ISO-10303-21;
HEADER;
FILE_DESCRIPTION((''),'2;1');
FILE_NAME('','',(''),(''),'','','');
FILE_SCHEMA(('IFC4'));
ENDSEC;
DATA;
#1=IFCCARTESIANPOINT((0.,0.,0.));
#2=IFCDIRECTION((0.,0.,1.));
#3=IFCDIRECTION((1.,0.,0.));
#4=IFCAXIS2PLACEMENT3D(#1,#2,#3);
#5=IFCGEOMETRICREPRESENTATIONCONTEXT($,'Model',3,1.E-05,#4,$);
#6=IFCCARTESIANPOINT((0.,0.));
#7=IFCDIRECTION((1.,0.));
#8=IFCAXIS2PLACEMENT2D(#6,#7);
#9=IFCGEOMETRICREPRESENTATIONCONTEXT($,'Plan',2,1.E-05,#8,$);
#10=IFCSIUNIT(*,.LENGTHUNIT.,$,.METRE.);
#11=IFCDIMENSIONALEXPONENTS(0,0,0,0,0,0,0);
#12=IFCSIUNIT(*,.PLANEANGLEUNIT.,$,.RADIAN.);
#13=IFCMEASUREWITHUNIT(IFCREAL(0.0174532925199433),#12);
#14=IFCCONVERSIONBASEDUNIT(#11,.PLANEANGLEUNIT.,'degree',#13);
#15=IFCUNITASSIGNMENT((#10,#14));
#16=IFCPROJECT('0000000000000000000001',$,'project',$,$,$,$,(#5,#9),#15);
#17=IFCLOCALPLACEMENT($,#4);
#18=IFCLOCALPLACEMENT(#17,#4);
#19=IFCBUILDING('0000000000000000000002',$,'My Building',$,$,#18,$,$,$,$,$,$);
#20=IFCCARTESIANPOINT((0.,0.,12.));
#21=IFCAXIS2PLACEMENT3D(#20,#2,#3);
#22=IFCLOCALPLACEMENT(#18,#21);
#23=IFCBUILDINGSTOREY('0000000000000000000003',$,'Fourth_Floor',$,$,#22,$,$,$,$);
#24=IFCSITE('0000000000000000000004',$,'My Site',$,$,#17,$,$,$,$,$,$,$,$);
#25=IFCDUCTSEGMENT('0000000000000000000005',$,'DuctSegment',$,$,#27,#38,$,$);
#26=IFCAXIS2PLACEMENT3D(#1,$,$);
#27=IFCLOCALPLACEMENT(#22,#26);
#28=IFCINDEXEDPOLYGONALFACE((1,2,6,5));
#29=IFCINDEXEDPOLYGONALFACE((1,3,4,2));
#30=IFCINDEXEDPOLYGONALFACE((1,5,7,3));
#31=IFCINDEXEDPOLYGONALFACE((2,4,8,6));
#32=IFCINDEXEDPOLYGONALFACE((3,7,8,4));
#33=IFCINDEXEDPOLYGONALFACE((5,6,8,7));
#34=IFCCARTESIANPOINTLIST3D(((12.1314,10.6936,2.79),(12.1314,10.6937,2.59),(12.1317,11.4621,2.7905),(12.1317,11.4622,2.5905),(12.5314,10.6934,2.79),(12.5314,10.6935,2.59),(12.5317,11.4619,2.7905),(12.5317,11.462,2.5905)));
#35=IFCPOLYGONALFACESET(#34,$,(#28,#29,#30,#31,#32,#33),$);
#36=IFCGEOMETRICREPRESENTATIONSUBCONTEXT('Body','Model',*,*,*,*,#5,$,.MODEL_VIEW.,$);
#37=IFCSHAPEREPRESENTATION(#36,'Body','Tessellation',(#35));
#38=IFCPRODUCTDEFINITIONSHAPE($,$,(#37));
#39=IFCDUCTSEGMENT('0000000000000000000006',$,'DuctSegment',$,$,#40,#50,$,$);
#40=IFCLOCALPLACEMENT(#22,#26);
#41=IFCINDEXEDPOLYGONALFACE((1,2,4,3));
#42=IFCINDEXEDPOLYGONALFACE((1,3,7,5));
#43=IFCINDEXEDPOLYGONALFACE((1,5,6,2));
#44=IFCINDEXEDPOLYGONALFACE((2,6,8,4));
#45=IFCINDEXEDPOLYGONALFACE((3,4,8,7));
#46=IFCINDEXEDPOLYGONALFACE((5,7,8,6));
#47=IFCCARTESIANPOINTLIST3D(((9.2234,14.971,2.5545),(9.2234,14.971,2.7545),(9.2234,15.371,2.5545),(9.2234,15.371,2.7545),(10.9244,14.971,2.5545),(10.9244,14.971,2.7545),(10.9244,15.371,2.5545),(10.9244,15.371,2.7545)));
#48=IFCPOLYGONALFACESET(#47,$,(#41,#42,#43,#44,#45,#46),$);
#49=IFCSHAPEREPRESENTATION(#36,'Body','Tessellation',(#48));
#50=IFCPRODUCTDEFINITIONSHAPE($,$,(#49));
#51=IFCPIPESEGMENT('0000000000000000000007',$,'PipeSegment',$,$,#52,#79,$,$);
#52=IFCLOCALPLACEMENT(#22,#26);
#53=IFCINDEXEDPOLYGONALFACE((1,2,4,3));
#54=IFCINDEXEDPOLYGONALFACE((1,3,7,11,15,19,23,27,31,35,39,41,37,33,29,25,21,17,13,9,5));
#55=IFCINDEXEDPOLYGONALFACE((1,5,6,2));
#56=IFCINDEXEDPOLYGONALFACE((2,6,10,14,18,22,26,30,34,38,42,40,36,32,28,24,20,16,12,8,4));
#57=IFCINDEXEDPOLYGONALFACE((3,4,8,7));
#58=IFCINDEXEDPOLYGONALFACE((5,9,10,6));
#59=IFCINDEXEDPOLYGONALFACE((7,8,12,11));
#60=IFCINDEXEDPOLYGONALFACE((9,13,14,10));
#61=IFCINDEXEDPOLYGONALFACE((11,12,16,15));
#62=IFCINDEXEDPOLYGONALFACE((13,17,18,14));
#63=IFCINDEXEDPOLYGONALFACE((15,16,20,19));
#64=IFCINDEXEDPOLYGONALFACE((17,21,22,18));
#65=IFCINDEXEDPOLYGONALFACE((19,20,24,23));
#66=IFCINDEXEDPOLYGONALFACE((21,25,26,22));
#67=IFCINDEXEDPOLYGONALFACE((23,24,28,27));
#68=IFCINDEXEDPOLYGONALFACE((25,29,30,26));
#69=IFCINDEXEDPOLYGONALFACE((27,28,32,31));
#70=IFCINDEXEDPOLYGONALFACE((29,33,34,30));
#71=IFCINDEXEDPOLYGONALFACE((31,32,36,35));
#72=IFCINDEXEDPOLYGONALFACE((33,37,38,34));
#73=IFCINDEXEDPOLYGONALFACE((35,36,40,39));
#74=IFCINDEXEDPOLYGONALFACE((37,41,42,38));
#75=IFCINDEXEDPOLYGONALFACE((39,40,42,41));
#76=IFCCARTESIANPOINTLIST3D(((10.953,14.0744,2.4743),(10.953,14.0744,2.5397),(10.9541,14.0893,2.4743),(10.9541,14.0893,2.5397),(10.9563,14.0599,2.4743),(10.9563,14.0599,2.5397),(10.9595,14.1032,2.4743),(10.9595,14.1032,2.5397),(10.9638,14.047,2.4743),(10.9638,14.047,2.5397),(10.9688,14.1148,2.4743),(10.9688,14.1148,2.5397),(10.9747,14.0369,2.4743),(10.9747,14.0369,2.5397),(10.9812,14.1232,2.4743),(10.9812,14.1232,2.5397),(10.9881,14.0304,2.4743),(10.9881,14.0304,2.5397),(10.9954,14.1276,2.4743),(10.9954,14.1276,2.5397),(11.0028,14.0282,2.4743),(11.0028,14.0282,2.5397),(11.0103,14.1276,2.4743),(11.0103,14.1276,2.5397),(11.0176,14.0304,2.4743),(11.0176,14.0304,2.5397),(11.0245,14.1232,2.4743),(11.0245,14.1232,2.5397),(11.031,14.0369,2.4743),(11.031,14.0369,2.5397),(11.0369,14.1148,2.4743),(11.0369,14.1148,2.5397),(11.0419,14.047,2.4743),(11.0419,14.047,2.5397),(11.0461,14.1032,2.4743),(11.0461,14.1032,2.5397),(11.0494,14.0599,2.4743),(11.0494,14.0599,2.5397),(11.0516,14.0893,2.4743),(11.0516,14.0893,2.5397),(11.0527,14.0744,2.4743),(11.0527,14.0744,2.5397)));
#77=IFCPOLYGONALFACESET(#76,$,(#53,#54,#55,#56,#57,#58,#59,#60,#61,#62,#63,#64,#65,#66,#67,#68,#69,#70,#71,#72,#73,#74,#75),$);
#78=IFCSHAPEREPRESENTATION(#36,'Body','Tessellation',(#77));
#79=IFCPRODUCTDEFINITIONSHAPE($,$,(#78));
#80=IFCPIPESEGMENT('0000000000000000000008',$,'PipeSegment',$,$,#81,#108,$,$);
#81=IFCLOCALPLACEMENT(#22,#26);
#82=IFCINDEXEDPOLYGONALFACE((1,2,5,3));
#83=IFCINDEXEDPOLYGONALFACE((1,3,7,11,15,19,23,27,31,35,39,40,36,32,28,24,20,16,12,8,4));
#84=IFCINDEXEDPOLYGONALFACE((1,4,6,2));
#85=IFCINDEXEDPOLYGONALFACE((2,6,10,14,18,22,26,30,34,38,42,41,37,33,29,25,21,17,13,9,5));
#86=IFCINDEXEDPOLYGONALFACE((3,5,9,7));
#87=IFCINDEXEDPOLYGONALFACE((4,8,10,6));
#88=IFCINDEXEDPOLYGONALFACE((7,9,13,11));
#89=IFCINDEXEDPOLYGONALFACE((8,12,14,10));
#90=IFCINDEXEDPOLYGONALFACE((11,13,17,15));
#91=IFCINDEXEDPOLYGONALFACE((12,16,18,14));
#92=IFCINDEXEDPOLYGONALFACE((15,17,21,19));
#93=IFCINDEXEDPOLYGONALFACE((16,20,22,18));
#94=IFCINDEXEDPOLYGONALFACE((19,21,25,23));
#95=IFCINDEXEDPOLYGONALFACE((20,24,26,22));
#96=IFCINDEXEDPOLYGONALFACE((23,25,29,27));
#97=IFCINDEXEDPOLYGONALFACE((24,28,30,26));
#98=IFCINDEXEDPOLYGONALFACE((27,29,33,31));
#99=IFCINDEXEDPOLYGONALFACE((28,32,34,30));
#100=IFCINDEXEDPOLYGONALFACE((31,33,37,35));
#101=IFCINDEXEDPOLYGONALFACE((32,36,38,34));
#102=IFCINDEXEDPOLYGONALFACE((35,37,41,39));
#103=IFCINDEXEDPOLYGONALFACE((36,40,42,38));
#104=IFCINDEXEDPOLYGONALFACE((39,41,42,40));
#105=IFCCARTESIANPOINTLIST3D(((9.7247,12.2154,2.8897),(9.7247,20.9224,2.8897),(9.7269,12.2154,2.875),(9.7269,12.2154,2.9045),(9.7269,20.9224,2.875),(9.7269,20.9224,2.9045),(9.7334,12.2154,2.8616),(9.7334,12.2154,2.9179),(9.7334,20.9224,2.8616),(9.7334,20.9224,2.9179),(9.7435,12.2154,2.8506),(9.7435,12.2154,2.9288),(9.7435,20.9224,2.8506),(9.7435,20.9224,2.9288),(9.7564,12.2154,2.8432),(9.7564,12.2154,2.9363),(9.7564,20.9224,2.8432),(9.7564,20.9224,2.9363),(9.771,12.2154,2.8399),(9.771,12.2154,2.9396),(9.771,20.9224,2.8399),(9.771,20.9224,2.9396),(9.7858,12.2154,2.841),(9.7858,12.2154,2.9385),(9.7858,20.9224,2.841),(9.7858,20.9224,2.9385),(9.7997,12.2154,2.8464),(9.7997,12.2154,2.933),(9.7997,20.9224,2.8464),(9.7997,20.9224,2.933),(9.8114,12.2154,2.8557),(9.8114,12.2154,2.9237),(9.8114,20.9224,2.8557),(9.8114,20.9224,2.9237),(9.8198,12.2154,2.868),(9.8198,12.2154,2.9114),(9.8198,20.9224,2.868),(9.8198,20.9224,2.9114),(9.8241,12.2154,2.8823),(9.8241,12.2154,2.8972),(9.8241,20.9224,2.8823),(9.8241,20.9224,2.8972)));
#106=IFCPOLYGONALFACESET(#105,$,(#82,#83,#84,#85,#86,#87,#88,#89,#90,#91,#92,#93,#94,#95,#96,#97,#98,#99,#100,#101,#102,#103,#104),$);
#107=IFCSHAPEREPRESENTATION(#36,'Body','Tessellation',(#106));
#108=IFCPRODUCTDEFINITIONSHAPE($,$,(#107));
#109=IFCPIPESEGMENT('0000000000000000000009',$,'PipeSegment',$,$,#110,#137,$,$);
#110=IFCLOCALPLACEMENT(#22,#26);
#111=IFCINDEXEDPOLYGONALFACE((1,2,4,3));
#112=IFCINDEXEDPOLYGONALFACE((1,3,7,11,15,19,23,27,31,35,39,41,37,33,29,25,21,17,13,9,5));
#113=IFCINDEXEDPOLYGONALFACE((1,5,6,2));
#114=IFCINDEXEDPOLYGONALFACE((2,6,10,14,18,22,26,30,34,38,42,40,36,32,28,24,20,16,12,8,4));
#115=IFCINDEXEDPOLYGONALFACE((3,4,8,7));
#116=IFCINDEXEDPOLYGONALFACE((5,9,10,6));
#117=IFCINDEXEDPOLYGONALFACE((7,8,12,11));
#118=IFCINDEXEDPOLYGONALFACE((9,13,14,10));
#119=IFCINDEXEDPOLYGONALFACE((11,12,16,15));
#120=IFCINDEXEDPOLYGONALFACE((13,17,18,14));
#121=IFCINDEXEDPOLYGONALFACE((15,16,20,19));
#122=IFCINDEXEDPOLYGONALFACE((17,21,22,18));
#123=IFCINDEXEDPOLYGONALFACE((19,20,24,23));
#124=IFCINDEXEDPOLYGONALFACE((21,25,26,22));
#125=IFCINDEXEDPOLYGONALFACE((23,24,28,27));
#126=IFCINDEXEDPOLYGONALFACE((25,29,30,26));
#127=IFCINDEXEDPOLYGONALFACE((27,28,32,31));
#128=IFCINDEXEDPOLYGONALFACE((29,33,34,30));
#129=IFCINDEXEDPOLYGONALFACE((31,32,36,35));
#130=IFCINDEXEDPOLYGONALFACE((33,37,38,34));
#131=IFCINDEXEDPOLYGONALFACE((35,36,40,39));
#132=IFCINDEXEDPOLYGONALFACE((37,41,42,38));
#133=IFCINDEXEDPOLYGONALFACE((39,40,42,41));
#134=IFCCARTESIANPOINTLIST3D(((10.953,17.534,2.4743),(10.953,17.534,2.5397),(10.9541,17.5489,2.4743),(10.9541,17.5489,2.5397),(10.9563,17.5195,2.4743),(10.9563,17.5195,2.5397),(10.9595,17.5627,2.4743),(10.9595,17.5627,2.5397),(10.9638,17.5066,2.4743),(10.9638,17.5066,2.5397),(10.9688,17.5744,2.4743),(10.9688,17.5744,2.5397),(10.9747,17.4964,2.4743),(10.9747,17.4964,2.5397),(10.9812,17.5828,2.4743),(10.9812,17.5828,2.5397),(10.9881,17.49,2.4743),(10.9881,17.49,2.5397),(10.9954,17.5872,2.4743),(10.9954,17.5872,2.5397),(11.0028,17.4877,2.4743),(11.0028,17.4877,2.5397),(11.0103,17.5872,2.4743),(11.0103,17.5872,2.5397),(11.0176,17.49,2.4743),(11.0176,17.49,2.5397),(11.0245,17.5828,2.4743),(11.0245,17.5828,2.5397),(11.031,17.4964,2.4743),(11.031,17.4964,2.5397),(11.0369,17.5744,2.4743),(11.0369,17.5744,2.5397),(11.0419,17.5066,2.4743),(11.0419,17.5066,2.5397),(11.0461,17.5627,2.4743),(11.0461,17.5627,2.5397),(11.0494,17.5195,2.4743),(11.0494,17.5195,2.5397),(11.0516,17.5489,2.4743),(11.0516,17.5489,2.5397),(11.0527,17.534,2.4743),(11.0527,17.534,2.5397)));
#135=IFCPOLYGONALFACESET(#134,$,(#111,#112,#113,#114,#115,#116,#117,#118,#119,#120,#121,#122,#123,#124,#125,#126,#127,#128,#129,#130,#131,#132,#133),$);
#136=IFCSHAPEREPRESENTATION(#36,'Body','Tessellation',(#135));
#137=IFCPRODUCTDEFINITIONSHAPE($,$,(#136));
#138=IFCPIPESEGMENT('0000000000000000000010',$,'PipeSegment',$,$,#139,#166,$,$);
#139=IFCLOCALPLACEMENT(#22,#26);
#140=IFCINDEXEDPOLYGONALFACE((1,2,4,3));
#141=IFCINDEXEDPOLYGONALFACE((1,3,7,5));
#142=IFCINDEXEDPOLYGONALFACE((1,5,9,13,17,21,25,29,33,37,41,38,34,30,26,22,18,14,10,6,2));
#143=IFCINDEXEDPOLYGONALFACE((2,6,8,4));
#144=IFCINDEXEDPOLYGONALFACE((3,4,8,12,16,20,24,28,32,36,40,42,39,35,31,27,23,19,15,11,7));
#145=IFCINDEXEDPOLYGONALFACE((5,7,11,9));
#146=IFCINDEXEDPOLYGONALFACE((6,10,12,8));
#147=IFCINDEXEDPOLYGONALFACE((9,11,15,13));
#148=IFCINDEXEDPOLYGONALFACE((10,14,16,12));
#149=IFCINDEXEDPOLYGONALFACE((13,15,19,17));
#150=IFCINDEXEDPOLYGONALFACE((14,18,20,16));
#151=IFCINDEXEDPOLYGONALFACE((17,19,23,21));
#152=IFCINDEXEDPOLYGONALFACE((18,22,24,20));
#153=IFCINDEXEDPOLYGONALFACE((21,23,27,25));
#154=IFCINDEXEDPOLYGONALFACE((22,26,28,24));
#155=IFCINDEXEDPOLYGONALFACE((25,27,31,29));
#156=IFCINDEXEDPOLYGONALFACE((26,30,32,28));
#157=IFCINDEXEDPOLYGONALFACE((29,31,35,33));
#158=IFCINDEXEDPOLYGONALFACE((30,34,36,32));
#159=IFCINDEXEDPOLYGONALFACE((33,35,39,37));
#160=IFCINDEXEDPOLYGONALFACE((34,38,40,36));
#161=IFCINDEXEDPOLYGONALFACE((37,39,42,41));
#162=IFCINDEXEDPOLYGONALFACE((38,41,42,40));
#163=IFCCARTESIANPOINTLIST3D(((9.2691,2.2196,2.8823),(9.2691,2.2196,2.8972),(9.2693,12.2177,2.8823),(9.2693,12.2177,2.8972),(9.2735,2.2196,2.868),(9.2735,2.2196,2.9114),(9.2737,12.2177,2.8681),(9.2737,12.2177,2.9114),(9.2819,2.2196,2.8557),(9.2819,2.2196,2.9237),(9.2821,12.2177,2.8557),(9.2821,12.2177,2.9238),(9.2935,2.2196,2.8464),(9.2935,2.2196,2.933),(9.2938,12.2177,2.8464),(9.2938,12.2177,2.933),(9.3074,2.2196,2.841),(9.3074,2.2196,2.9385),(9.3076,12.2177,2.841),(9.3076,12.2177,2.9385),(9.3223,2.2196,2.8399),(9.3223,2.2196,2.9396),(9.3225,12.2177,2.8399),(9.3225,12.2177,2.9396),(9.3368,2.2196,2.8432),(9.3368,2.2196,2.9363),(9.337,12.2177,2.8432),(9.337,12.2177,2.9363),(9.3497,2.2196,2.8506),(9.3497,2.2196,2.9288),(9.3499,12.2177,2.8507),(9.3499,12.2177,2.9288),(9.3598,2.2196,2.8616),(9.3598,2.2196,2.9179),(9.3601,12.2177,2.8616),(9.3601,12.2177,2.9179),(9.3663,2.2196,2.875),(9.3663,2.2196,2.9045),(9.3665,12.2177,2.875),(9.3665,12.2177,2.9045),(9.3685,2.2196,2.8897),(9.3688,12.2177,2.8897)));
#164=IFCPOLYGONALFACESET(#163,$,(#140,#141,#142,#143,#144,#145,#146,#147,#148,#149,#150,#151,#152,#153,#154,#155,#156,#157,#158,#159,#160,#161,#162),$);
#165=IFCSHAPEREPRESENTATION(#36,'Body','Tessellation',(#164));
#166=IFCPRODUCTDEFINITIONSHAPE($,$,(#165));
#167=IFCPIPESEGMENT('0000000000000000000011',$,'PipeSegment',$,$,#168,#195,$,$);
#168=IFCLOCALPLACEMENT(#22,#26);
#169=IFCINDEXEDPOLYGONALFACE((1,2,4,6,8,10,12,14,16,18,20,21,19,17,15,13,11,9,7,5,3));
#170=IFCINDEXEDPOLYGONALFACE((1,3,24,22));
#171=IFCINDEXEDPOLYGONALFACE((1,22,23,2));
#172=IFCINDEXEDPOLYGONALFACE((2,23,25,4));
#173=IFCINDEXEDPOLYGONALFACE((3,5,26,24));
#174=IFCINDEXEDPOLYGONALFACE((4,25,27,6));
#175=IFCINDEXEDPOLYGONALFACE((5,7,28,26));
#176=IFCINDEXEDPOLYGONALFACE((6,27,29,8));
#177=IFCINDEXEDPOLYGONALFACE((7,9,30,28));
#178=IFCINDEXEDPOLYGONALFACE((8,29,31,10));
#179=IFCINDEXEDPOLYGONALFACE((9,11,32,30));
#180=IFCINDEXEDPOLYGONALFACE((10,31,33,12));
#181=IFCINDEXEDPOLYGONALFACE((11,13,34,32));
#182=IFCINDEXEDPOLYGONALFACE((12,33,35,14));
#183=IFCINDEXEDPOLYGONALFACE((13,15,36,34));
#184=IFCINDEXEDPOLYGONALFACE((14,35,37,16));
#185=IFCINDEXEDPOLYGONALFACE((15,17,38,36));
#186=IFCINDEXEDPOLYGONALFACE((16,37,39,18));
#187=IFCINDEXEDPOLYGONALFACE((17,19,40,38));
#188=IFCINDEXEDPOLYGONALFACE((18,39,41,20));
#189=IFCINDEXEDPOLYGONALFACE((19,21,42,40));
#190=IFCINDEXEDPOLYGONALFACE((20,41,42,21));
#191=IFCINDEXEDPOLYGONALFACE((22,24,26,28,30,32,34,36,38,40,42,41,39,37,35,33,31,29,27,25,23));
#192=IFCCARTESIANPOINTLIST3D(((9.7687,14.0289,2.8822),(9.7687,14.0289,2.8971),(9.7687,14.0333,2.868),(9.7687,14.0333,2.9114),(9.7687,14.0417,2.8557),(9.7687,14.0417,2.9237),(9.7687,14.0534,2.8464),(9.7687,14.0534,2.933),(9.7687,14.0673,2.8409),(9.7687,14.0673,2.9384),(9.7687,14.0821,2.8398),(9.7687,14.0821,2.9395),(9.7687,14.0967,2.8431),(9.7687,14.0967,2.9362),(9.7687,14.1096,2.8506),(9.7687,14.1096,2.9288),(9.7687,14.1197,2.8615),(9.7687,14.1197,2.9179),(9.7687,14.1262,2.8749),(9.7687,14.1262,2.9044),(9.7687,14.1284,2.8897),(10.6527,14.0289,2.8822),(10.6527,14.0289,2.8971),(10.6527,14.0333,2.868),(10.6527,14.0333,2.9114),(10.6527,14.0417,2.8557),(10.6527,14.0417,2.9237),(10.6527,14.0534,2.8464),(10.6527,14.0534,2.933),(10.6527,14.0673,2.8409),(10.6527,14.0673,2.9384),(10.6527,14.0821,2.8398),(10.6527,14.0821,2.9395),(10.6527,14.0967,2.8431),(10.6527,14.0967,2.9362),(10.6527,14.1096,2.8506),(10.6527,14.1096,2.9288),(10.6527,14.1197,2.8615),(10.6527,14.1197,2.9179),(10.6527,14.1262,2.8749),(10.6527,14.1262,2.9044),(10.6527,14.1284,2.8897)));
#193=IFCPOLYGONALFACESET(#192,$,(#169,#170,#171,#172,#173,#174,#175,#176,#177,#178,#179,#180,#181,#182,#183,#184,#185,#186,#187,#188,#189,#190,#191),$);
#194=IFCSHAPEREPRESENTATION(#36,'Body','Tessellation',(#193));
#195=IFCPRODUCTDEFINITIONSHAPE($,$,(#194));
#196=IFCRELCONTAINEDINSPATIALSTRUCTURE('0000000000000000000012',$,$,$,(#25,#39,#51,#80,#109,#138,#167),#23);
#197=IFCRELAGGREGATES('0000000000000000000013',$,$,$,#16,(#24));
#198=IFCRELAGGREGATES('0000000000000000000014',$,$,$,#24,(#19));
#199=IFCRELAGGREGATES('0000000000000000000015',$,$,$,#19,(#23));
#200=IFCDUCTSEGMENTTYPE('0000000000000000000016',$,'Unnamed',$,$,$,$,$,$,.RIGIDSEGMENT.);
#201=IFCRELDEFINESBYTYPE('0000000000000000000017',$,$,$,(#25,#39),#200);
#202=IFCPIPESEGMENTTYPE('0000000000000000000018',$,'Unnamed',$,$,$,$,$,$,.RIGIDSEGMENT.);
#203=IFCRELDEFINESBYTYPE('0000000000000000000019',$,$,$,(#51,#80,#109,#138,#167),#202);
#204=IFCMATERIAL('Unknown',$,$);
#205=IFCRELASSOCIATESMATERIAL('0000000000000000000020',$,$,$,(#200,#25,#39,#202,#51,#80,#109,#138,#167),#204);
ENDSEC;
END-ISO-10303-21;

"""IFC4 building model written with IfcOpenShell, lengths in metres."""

from ifc_helpers import new_model, entity, si_unit, converted_unit, frame, origin_with_axes, origin_2d_with_axis, place, context, subcontext, project, spatial, rectangle, circle, extrude, material, material_profile, profile_set, profile_usage, type_object, element, save


model = new_model("IFC4")

# Units and contexts
model_context = context("Model", 3, precision=1e-05, world=origin_with_axes())
plan_context = context("Plan", 2, precision=1e-05, world=origin_2d_with_axis())
body_context_1 = subcontext(model_context, "Body", "Model", "MODEL_VIEW")
ifc_project = project(units=[si_unit("LENGTHUNIT", "METRE"), converted_unit("PLANEANGLEUNIT", "degree", entity("IfcReal", 0.0174532925199433), si_unit("PLANEANGLEUNIT", "RADIAN"), dimensions=[0, 0, 0, 0, 0, 0, 0])], contexts=[model_context, plan_context])

# Site, building, storey
site_placement = place(None, origin_with_axes())
site = spatial("IfcSite", under=ifc_project, at=site_placement, Name="My Site")
building_placement = place(site_placement, origin_with_axes())
building = spatial("IfcBuilding", under=site, at=building_placement, Name="My Building")
storey_placement = place(building_placement, frame((0.0, 0.0, 12.0), z_axis=(0.0, 0.0, 1.0), x_axis=(1.0, 0.0, 0.0)))
storey = spatial("IfcBuildingStorey", under=building, at=storey_placement, Name="Fourth_Floor")

# Shared definitions
ifc_material = material(Name="Unknown")

# Duct segments
ifc_material_profile_1 = material_profile(ifc_material, rectangle(XDim=0.4, YDim=0.2))
ifc_profile_set_1 = profile_set([ifc_material_profile_1])
duct_segment_type = type_object("IfcDuctSegmentType", Name="Unnamed", PredefinedType="RIGIDSEGMENT", material=ifc_profile_set_1)
ifc_profile_usage_1 = profile_usage(ifc_profile_set_1, cardinal=5)
duct_segment_1_placement = place(storey_placement, frame((12.3317, 11.462, 2.6905), z_axis=(-0.000397, -1.0, -0.000603), x_axis=(1.0, -0.000397, 0.0)))
element("IfcDuctSegment", 1, at=duct_segment_1_placement, inside=storey, type_object=duct_segment_type, material=ifc_profile_usage_1, Name="DuctSegment", context=body_context_1, shape_type="SweptSolid", body=[
    extrude(rectangle(XDim=0.4, YDim=0.2), origin_with_axes(), (0.0, 0.0, 1.0), 0.7685),
])
ifc_profile_usage_2 = profile_usage(ifc_profile_set_1, cardinal=5)
duct_segment_2_placement = place(storey_placement, frame((9.2234, 15.171, 2.6545), z_axis=(1.0, -0.000001, 0.000001), x_axis=(0.000001, 1.0, 0.0)))
element("IfcDuctSegment", 2, at=duct_segment_2_placement, inside=storey, type_object=duct_segment_type, material=ifc_profile_usage_2, Name="DuctSegment", context=body_context_1, shape_type="SweptSolid", body=[
    extrude(rectangle(XDim=0.4, YDim=0.2), origin_with_axes(), (0.0, 0.0, 1.0), 1.701),
])

# Pipe segments
ifc_material_profile_2 = material_profile(ifc_material, circle(Radius=0.05))
ifc_profile_set_2 = profile_set([ifc_material_profile_2])
ifc_profile_usage_3 = profile_usage(ifc_profile_set_2, cardinal=5)
pipe_segment_type = type_object("IfcPipeSegmentType", Name="Unnamed", PredefinedType="RIGIDSEGMENT", material=ifc_profile_set_2)
pipe_segment_1_placement = place(storey_placement, frame((11.0028, 14.0782, 2.4743), z_axis=(0.0, 0.0, 1.0), x_axis=(0.000001, -1.0, 0.0)))
element("IfcPipeSegment", 3, at=pipe_segment_1_placement, inside=storey, type_object=pipe_segment_type, material=ifc_profile_usage_3, Name="PipeSegment", context=body_context_1, shape_type="SweptSolid", body=[
    extrude(circle(Radius=0.05), origin_with_axes(), (0.0, 0.0, 1.0), 0.0654),
])
ifc_profile_usage_4 = profile_usage(ifc_profile_set_2, cardinal=5)
pipe_segment_2_placement = place(storey_placement, frame((9.7747, 12.2154, 2.8897), z_axis=(0.0, 1.0, 0.0), x_axis=(-1.0, 0.0, 0.0)))
element("IfcPipeSegment", 4, at=pipe_segment_2_placement, inside=storey, type_object=pipe_segment_type, material=ifc_profile_usage_4, Name="PipeSegment", context=body_context_1, shape_type="SweptSolid", body=[
    extrude(circle(Radius=0.05), origin_with_axes(), (0.0, 0.0, 1.0), 8.707),
])
ifc_profile_usage_5 = profile_usage(ifc_profile_set_2, cardinal=5)
pipe_segment_3_placement = place(storey_placement, frame((11.0028, 17.5377, 2.4743), z_axis=(0.0, 0.0, 1.0), x_axis=(0.000001, -1.0, 0.0)))
element("IfcPipeSegment", 5, at=pipe_segment_3_placement, inside=storey, type_object=pipe_segment_type, material=ifc_profile_usage_5, Name="PipeSegment", context=body_context_1, shape_type="SweptSolid", body=[
    extrude(circle(Radius=0.05), origin_with_axes(), (0.0, 0.0, 1.0), 0.0654),
])
ifc_profile_usage_6 = profile_usage(ifc_profile_set_2, cardinal=5)
pipe_segment_4_placement = place(storey_placement, frame((9.3188, 12.2177, 2.8897), z_axis=(-0.000022, -1.0, -0.000003), x_axis=(1.0, -0.000022, 0.0)))
element("IfcPipeSegment", 6, at=pipe_segment_4_placement, inside=storey, type_object=pipe_segment_type, material=ifc_profile_usage_6, Name="PipeSegment", context=body_context_1, shape_type="SweptSolid", body=[
    extrude(circle(Radius=0.05), origin_with_axes(), (0.0, 0.0, 1.0), 9.9981),
])
ifc_profile_usage_7 = profile_usage(ifc_profile_set_2, cardinal=5)
pipe_segment_5_placement = place(storey_placement, frame((9.7687, 14.0784, 2.8897), z_axis=(1.0, 0.0, 0.0), x_axis=(0.0, 1.0, 0.0)))
element("IfcPipeSegment", 7, at=pipe_segment_5_placement, inside=storey, type_object=pipe_segment_type, material=ifc_profile_usage_7, Name="PipeSegment", context=body_context_1, shape_type="SweptSolid", body=[
    extrude(circle(Radius=0.05), origin_with_axes(), (0.0, 0.0, 1.0), 0.884),
])

save(model, "model.ifc")
